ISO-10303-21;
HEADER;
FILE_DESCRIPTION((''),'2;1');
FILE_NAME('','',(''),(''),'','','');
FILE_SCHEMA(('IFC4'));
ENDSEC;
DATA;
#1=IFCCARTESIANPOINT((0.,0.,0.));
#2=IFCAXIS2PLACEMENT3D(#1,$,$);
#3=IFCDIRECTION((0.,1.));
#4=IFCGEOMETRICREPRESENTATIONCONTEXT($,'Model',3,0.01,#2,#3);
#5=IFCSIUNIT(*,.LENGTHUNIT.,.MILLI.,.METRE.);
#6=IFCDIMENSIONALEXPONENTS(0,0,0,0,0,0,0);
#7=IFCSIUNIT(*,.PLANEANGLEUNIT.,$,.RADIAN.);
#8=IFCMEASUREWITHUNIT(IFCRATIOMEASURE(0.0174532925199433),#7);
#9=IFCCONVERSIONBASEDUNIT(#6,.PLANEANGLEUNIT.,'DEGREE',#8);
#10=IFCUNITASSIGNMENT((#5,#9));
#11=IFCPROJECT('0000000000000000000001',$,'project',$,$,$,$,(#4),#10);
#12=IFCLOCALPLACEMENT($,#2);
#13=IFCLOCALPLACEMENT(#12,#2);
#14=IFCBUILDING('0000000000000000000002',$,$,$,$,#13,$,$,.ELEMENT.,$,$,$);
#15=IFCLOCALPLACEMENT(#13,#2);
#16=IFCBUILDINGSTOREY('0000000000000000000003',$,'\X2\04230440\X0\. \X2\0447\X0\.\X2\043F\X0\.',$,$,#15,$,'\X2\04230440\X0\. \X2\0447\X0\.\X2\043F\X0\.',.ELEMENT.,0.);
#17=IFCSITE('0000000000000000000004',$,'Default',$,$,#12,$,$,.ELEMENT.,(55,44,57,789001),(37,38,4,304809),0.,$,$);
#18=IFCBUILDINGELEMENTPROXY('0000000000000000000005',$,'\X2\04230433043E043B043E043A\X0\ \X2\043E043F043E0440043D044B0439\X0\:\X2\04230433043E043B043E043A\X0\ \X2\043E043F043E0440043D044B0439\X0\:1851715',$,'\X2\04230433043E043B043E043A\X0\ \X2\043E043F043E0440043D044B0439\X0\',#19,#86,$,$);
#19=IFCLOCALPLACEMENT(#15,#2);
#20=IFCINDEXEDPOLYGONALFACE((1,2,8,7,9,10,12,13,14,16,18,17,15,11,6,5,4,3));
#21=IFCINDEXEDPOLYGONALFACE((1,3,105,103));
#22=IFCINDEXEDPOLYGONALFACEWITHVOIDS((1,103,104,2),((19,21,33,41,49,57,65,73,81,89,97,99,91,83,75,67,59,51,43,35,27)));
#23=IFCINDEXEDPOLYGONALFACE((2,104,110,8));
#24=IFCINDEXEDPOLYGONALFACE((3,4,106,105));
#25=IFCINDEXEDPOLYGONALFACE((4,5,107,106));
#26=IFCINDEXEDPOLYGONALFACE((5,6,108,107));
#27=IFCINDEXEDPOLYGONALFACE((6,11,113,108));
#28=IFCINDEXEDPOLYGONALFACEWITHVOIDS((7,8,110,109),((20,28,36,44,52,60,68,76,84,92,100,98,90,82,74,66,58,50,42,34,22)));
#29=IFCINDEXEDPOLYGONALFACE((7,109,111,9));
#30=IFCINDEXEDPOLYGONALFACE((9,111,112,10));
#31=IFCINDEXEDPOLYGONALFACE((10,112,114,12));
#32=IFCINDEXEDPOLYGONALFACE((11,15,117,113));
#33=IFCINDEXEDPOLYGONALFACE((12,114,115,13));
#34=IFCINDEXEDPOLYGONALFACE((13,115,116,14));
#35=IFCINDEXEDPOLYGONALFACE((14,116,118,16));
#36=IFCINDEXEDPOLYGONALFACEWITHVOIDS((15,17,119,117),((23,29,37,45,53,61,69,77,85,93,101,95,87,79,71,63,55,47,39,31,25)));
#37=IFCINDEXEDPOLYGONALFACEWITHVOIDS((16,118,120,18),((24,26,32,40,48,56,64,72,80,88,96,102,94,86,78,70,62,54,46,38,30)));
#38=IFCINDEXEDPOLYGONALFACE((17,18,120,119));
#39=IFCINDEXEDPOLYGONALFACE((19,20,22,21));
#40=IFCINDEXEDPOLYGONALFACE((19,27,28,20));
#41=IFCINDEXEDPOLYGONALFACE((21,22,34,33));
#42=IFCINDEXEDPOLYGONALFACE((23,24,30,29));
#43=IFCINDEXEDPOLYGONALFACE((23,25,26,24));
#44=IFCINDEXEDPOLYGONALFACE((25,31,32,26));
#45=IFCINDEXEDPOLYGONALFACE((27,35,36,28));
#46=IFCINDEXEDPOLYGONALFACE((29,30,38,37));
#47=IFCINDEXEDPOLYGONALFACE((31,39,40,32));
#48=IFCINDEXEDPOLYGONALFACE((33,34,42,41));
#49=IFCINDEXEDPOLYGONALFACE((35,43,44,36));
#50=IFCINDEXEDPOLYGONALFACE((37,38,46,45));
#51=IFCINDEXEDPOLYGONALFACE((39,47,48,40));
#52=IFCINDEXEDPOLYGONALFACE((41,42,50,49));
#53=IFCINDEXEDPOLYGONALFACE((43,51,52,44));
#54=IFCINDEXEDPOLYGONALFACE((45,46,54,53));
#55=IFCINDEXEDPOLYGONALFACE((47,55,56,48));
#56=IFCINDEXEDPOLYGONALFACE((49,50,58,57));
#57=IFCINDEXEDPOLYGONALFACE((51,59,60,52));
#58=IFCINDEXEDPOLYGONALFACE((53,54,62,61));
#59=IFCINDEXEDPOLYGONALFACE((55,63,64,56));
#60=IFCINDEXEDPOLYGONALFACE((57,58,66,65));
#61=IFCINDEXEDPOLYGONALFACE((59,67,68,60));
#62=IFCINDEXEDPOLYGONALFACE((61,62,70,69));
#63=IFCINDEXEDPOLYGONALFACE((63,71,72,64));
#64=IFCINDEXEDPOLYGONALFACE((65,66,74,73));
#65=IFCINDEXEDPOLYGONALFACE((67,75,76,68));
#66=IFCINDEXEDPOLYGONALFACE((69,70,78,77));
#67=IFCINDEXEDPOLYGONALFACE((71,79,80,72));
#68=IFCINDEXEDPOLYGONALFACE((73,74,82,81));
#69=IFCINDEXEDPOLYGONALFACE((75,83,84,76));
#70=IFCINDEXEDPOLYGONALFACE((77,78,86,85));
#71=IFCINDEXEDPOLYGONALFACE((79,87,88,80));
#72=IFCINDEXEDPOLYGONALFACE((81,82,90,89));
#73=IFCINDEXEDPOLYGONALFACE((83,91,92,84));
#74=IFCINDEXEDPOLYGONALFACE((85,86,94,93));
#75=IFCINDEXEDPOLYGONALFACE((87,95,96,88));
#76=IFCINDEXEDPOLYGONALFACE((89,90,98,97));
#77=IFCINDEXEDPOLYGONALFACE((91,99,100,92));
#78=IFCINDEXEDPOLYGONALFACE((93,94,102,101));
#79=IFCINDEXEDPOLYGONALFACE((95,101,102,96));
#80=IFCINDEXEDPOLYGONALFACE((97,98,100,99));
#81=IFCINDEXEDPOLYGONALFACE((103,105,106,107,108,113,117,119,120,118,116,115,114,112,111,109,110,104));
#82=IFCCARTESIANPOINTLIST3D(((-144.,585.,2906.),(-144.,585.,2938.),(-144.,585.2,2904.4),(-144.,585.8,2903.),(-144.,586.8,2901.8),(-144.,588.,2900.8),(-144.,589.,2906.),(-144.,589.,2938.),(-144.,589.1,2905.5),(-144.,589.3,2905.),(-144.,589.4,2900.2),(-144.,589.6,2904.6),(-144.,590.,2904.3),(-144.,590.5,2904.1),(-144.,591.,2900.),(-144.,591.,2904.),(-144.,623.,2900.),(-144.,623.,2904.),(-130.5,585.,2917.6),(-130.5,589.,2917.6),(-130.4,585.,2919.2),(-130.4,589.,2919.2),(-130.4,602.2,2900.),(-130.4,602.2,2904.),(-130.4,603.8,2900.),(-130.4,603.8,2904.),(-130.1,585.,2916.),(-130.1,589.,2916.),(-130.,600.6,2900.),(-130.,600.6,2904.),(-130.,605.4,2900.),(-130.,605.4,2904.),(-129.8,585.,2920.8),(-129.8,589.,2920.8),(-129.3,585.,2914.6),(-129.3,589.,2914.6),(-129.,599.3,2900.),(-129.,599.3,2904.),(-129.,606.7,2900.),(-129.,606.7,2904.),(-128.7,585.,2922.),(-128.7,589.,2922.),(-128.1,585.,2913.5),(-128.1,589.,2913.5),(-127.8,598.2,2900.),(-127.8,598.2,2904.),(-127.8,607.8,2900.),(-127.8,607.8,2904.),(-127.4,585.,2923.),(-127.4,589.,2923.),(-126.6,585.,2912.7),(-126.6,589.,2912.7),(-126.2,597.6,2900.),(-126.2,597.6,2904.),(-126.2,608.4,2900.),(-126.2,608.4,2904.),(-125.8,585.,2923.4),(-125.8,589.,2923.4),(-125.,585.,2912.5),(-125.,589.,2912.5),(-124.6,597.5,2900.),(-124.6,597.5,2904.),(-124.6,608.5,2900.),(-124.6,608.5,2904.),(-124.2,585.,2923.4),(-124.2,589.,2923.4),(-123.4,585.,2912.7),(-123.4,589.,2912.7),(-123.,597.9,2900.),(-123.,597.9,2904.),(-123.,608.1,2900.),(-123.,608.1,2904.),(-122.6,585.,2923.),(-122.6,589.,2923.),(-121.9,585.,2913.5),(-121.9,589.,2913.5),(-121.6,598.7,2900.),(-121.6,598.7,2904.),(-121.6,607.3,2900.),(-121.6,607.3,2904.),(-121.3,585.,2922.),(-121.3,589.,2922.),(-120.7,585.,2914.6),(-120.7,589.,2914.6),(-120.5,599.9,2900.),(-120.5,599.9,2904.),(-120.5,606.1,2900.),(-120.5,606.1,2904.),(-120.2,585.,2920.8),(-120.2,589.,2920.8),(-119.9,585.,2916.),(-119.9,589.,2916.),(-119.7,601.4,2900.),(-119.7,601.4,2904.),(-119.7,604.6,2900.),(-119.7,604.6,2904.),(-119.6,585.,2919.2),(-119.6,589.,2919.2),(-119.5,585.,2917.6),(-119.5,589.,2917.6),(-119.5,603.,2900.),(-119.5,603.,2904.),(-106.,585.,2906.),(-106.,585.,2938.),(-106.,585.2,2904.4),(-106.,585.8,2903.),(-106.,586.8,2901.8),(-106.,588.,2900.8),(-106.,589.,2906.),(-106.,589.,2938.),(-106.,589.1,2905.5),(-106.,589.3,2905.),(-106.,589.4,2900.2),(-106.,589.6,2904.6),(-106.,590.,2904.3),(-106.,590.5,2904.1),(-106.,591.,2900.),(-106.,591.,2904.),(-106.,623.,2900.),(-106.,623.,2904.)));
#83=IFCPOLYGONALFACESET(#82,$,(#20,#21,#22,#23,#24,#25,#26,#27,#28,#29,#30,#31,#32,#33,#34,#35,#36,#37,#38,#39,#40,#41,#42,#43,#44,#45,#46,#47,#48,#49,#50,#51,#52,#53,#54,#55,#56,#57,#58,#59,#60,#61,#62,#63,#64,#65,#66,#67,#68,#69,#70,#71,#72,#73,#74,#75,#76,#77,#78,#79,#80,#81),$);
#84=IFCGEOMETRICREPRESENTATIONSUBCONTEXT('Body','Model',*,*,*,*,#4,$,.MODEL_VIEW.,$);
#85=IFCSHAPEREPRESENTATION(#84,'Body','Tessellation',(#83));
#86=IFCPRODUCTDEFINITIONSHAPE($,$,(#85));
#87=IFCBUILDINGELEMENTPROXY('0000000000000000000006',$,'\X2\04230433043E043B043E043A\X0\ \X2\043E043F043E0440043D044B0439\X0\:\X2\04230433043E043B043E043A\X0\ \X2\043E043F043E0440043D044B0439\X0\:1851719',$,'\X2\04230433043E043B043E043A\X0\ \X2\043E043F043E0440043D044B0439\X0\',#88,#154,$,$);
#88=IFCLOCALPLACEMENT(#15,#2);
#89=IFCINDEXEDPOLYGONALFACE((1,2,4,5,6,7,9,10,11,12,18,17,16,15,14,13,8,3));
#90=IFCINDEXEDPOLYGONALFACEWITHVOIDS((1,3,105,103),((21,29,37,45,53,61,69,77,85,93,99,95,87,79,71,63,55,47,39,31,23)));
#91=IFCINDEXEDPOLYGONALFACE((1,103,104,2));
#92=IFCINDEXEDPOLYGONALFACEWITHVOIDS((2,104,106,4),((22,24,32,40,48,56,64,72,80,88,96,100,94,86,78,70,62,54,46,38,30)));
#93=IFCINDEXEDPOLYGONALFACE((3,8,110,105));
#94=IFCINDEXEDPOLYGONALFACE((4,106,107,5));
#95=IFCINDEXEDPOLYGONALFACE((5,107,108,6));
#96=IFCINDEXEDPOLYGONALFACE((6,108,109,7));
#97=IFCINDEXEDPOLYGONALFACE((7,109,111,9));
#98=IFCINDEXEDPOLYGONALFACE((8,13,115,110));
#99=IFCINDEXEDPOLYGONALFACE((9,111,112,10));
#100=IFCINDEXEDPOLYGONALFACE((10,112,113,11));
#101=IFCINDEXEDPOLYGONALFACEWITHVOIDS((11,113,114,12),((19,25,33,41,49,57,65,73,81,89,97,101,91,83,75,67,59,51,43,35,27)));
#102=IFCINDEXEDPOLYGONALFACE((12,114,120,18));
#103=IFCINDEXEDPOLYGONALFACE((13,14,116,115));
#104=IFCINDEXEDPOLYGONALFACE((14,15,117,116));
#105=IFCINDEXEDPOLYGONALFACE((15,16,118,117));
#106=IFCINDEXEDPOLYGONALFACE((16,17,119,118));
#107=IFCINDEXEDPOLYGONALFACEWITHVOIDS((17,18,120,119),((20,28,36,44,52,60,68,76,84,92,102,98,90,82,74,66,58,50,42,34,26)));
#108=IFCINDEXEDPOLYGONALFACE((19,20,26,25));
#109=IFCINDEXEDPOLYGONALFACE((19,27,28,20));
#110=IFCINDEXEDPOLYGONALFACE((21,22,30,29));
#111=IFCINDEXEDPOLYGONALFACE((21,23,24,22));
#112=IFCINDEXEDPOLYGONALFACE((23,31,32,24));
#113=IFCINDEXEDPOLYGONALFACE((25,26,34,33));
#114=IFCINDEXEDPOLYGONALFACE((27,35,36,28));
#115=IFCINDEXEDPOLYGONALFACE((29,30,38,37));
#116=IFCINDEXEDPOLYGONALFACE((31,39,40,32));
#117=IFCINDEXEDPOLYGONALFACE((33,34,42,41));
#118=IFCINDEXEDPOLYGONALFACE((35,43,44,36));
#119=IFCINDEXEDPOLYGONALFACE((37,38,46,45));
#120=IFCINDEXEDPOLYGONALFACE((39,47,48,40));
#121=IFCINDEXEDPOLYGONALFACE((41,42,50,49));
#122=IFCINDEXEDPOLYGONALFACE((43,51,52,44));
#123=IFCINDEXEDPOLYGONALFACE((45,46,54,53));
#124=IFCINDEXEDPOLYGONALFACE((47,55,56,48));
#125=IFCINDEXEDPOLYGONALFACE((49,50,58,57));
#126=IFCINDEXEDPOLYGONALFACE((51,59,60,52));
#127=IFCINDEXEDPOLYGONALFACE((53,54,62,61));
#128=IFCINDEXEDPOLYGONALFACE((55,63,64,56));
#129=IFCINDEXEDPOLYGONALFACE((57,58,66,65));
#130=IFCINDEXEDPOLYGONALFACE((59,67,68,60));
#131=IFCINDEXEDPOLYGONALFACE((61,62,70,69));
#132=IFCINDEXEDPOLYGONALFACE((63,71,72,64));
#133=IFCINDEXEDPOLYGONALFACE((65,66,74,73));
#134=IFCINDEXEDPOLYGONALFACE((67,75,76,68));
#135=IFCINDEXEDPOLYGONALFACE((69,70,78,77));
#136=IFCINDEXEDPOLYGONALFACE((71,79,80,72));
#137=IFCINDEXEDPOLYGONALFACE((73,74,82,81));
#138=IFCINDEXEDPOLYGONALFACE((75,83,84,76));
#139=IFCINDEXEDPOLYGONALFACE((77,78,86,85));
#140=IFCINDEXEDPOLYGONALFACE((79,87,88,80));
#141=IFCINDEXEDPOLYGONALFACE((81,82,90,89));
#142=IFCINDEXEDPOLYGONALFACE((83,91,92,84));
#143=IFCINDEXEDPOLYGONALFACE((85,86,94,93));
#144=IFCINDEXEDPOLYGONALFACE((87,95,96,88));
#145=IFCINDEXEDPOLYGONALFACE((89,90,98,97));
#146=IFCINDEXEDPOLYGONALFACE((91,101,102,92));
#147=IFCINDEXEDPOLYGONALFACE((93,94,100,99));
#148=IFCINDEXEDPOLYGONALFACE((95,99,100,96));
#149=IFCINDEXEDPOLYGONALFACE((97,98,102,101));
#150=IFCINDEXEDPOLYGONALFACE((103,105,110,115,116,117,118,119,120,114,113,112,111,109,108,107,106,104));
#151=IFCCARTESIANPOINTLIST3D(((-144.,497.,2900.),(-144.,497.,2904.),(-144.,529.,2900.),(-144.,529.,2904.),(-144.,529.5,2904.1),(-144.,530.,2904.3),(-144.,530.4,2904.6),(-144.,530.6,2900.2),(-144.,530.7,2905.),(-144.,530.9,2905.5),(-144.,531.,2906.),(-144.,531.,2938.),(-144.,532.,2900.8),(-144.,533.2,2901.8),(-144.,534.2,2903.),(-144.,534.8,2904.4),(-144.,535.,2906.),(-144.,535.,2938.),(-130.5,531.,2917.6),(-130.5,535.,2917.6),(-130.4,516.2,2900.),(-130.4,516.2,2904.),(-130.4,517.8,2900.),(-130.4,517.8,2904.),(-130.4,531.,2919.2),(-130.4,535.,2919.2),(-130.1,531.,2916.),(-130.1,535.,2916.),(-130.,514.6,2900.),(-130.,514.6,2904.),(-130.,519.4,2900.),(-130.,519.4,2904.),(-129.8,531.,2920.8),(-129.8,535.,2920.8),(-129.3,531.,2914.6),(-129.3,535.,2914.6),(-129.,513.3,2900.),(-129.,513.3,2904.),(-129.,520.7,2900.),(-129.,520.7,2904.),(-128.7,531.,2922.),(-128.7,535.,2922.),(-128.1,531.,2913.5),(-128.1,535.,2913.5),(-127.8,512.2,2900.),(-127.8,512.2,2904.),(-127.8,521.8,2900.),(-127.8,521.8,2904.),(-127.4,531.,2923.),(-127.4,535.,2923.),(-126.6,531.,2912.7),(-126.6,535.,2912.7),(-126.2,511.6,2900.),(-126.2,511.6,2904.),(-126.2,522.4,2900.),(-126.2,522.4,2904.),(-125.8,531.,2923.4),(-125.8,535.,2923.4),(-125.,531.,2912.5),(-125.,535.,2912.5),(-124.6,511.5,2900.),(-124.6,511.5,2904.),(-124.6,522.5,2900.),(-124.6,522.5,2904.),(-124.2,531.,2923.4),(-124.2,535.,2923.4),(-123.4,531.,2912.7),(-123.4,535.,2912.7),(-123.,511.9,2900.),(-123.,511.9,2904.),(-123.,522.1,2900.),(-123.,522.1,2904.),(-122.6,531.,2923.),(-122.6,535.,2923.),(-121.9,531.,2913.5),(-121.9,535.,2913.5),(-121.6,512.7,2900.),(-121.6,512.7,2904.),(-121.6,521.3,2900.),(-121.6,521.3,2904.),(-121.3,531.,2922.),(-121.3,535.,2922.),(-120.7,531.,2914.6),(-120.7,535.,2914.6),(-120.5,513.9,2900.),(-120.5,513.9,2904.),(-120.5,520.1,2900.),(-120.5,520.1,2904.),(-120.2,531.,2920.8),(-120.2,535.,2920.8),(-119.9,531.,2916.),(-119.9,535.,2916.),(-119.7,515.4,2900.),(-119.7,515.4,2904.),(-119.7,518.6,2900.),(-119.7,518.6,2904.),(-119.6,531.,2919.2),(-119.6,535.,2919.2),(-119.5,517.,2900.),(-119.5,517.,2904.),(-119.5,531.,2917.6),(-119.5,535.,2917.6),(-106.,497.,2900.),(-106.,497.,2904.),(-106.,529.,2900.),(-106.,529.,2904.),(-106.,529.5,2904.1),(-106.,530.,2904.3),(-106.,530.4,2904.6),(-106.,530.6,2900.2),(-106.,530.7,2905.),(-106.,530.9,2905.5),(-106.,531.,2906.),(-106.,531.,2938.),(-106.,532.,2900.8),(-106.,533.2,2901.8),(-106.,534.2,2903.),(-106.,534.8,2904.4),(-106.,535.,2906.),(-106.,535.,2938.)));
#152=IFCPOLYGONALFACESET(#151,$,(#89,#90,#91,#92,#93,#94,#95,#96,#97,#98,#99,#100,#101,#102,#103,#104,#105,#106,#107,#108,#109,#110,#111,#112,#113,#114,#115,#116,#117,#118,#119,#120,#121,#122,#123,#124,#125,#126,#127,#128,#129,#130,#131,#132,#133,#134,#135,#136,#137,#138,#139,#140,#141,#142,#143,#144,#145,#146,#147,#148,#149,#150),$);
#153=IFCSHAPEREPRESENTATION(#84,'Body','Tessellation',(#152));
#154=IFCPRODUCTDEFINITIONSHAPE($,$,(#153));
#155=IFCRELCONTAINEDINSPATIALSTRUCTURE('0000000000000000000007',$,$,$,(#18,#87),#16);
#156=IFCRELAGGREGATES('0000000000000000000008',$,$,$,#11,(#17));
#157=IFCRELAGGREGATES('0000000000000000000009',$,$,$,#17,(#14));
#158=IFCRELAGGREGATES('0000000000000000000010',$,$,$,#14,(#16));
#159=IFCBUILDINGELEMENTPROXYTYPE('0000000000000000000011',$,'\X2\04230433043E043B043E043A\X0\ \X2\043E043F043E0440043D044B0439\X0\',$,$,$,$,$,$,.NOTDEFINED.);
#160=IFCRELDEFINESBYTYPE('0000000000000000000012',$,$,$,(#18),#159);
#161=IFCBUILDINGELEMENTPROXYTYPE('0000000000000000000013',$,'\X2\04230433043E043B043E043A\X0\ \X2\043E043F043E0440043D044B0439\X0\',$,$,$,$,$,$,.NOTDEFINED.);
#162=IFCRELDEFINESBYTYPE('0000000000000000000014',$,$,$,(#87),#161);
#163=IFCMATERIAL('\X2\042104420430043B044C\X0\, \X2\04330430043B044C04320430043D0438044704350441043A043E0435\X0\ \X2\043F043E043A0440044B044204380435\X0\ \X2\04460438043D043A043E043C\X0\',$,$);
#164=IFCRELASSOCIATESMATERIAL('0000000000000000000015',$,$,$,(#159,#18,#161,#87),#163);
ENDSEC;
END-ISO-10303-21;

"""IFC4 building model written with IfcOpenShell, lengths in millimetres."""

from ifc_helpers import new_model, entity, si_unit, converted_unit, direction, frame, frame_2d, origin, place, context, subcontext, project, spatial, polyline, circle_curve, parameter, trimmed, segment, composite_curve, circle, outline, extrude, source, transform, mapped, material, type_object, type_shapes, element, save


model = new_model("IFC4")

# Units and contexts
model_context = context("Model", 3, precision=0.01, world=origin(), true_north=direction((0.0, 1.0)))
body_context = subcontext(model_context, "Body", "Model", "MODEL_VIEW")
ifc_project = project(units=[si_unit("LENGTHUNIT", "METRE", prefix="MILLI"), converted_unit("PLANEANGLEUNIT", "DEGREE", entity("IfcRatioMeasure", 0.0174532925199433), si_unit("PLANEANGLEUNIT", "RADIAN"), dimensions=[0, 0, 0, 0, 0, 0, 0])], contexts=[model_context])

# Site, building, storey
site_placement = place(None, origin())
site = spatial("IfcSite", under=ifc_project, at=site_placement, Name="Default", CompositionType="ELEMENT", RefLatitude=(55, 44, 57, 789001), RefLongitude=(37, 38, 4, 304809), RefElevation=0.0)
building_placement = place(site_placement, origin())
building = spatial("IfcBuilding", under=site, at=building_placement, CompositionType="ELEMENT")
storey_placement = place(building_placement, origin())
storey = spatial("IfcBuildingStorey", under=building, at=storey_placement, Name="Ур. ч.п.", LongName="Ур. ч.п.", CompositionType="ELEMENT", Elevation=0.0)

# Building element proxies, openings
ifc_material_1 = material(Name="Сталь, гальваническое покрытие цинком")
building_element_proxy_type_1 = type_object("IfcBuildingElementProxyType", Name="Уголок опорный", material=ifc_material_1)
shared_shape_1 = source(origin(), body_context, "Body", "SweptSolid", [
    extrude(outline(composite_curve([segment(polyline([(-6.0, -12.0), (26.0, -12.0)]), True, "CONTINUOUS"), segment(polyline([(26.0, -12.0), (26.0, -8.0)]), True, "CONTINUOUS"), segment(polyline([(26.0, -8.0), (-6.0, -8.0)]), True, "CONTINUOUS"), segment(trimmed(circle_curve(frame_2d((-6.0, -6.0), x_axis=(0.0, -1.0)), 2.0), [parameter(270.0)], [parameter(0.0)], True, "PARAMETER"), False, "CONTINUOUS"), segment(polyline([(-8.0, -6.0), (-8.0, 26.0)]), True, "CONTINUOUS"), segment(polyline([(-8.0, 26.0), (-12.0, 26.0)]), True, "CONTINUOUS"), segment(polyline([(-12.0, 26.0), (-12.0, -6.0)]), True, "CONTINUOUS"), segment(trimmed(circle_curve(frame_2d((-6.0, -6.0), x_axis=(0.0, -1.0)), 6.0), [parameter(270.0)], [parameter(360.0)], True, "PARAMETER"), True, "CONTINUOUS")], self_intersect=False)), frame((12.0, -19.0, 12.0), z_axis=(0.0, 1.0, 0.0), x_axis=(0.0, 0.0, 1.0)), (0.0, 0.0, 1.0), 38.0),
])
type_shapes(building_element_proxy_type_1, [shared_shape_1])
proxy_1_placement = place(storey_placement, frame((-125.0, 585.0, 2900.0), z_axis=(0.0, 0.0, 1.0), x_axis=(0.0, 1.0, 0.0)))
proxy_1 = element("IfcBuildingElementProxy", 1, at=proxy_1_placement, inside=storey, type_object=building_element_proxy_type_1, material=ifc_material_1, Name="Уголок опорный:Уголок опорный:1851715", ObjectType="Уголок опорный", context=body_context, shape_type="MappedRepresentation", body=[
    mapped(shared_shape_1, transform((0.0, 0.0, 0.0), scale=1.0)),
])
opening_1_placement = place(storey_placement, frame((-125.0, 585.0, 2900.0), z_axis=(0.0, 0.0, 1.0), x_axis=(-1.0, 0.0, 0.0)))
element("IfcOpeningElement", 2, at=opening_1_placement, cuts=proxy_1, ObjectType="Opening", PredefinedType="OPENING", context=body_context, shape_type="SweptSolid", body=[
    extrude(circle(Radius=5.5, at=frame_2d((0.0, 0.0), x_axis=(1.0, 0.0))), frame((0.0, -4.0, 18.0), z_axis=(0.0, 1.0, 0.0), x_axis=(0.0, 0.0, -1.0)), (0.0, 0.0, 1.0), 4.0),
])
opening_2_placement = place(storey_placement, frame((-125.0, 585.0, 2900.0), z_axis=(0.0, 0.0, 1.0), x_axis=(-1.0, 0.0, 0.0)))
element("IfcOpeningElement", 3, at=opening_2_placement, cuts=proxy_1, ObjectType="Opening", PredefinedType="OPENING", context=body_context, shape_type="SweptSolid", body=[
    extrude(circle(Radius=5.5, at=frame_2d((0.0, 0.0), x_axis=(1.0, 0.0))), frame((0.0, -18.0, 0.0), z_axis=(0.0, 0.0, 1.0), x_axis=(-1.0, 0.0, 0.0)), (0.0, 0.0, 1.0), 4.0),
])
building_element_proxy_type_2 = type_object("IfcBuildingElementProxyType", Name="Уголок опорный", material=ifc_material_1)
shared_shape_2 = source(origin(), body_context, "Body", "SweptSolid", [
    extrude(outline(composite_curve([segment(polyline([(-6.0, -12.0), (26.0, -12.0)]), True, "CONTINUOUS"), segment(polyline([(26.0, -12.0), (26.0, -8.0)]), True, "CONTINUOUS"), segment(polyline([(26.0, -8.0), (-6.0, -8.0)]), True, "CONTINUOUS"), segment(trimmed(circle_curve(frame_2d((-6.0, -6.0), x_axis=(0.0, -1.0)), 2.0), [parameter(270.0)], [parameter(0.0)], True, "PARAMETER"), False, "CONTINUOUS"), segment(polyline([(-8.0, -6.0), (-8.0, 26.0)]), True, "CONTINUOUS"), segment(polyline([(-8.0, 26.0), (-12.0, 26.0)]), True, "CONTINUOUS"), segment(polyline([(-12.0, 26.0), (-12.0, -6.0)]), True, "CONTINUOUS"), segment(trimmed(circle_curve(frame_2d((-6.0, -6.0), x_axis=(0.0, -1.0)), 6.0), [parameter(270.0)], [parameter(360.0)], True, "PARAMETER"), True, "CONTINUOUS")], self_intersect=False)), frame((12.0, -19.0, 12.0), z_axis=(0.0, 1.0, 0.0), x_axis=(0.0, 0.0, 1.0)), (0.0, 0.0, 1.0), 38.0),
])
type_shapes(building_element_proxy_type_2, [shared_shape_2])
proxy_2_placement = place(storey_placement, frame((-125.0, 535.0, 2900.0), z_axis=(0.0, 0.0, 1.0), x_axis=(0.0, -1.0, 0.0)))
proxy_2 = element("IfcBuildingElementProxy", 4, at=proxy_2_placement, inside=storey, type_object=building_element_proxy_type_2, material=ifc_material_1, Name="Уголок опорный:Уголок опорный:1851719", ObjectType="Уголок опорный", context=body_context, shape_type="MappedRepresentation", body=[
    mapped(shared_shape_2, transform((0.0, 0.0, 0.0), scale=1.0)),
])
opening_3_placement = place(storey_placement, frame((-125.0, 535.0, 2900.0), z_axis=(0.0, 0.0, 1.0), x_axis=(-1.0, 0.0, 0.0)))
element("IfcOpeningElement", 5, at=opening_3_placement, cuts=proxy_2, ObjectType="Opening", PredefinedType="OPENING", context=body_context, shape_type="SweptSolid", body=[
    extrude(circle(Radius=5.5, at=frame_2d((0.0, 0.0), x_axis=(1.0, 0.0))), frame((0.0, 0.0, 18.0), z_axis=(0.0, 1.0, 0.0), x_axis=(0.0, 0.0, -1.0)), (0.0, 0.0, 1.0), 4.0),
])
opening_4_placement = place(storey_placement, frame((-125.0, 535.0, 2900.0), z_axis=(0.0, 0.0, 1.0), x_axis=(-1.0, 0.0, 0.0)))
element("IfcOpeningElement", 6, at=opening_4_placement, cuts=proxy_2, ObjectType="Opening", PredefinedType="OPENING", context=body_context, shape_type="SweptSolid", body=[
    extrude(circle(Radius=5.5, at=frame_2d((0.0, 0.0), x_axis=(1.0, 0.0))), frame((0.0, 18.0, 0.0), z_axis=(0.0, 0.0, 1.0), x_axis=(-1.0, 0.0, 0.0)), (0.0, 0.0, 1.0), 4.0),
])

save(model, "model.ifc")
